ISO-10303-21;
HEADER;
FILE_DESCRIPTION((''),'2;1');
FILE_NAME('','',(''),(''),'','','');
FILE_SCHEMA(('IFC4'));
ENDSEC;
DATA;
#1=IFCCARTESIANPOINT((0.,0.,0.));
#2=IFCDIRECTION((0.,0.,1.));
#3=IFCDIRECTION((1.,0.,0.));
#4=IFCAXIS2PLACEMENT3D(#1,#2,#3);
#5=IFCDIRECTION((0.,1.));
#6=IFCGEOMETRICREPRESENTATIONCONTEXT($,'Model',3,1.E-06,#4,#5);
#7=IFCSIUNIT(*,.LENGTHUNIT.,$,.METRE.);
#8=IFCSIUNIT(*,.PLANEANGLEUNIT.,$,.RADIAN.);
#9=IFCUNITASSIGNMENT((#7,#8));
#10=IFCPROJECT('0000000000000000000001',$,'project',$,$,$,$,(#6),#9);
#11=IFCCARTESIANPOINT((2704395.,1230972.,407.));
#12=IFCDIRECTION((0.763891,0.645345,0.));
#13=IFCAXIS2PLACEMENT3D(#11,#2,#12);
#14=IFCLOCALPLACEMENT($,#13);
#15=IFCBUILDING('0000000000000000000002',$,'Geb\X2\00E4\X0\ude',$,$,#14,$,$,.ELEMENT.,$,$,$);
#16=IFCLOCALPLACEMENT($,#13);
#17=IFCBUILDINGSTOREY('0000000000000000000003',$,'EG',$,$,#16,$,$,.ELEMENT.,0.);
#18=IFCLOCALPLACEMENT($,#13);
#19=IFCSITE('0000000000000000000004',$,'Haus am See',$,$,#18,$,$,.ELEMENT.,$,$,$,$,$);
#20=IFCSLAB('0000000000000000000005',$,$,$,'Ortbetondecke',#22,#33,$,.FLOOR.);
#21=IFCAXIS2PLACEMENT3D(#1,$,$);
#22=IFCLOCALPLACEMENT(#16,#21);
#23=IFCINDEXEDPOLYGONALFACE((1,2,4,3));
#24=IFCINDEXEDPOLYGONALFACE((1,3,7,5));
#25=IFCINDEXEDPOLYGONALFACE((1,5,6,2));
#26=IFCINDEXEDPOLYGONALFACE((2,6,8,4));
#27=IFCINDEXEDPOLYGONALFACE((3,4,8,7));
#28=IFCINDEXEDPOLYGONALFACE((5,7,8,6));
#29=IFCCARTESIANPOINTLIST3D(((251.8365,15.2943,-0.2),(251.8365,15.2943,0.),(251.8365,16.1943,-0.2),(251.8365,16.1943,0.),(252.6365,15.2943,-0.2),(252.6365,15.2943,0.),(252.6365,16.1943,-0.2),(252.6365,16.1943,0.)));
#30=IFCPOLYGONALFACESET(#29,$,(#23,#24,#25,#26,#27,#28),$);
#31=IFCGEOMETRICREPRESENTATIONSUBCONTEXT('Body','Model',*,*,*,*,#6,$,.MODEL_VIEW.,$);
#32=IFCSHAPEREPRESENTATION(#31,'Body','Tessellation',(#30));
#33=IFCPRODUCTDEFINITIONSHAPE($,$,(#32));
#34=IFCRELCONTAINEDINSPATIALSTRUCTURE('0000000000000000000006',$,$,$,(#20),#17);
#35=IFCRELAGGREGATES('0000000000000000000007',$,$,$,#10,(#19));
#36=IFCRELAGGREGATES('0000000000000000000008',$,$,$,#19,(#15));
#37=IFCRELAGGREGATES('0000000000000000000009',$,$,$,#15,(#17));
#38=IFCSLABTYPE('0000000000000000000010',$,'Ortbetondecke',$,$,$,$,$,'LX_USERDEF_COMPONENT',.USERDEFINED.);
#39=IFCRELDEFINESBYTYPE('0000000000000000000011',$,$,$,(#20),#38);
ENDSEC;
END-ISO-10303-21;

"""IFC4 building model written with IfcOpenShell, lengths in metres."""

from ifc_helpers import new_model, si_unit, direction, frame, origin_with_axes, origin_2d_with_axis, place, context, subcontext, project, spatial, rectangle, extrude, type_object, element, save


model = new_model("IFC4")

# Units and contexts
model_context = context("Model", 3, precision=1e-06, world=origin_with_axes(), true_north=direction((0.0, 1.0)))
body_context = subcontext(model_context, "Body", "Model", "MODEL_VIEW")
ifc_project = project(units=[si_unit("LENGTHUNIT", "METRE"), si_unit("PLANEANGLEUNIT", "RADIAN")], contexts=[model_context])

# Site, building, storey
site_placement = place(None, frame((2704395.0, 1230972.0, 407.0), z_axis=(0.0, 0.0, 1.0), x_axis=(0.763891, 0.645345, 0.0)))
site = spatial("IfcSite", under=ifc_project, at=site_placement, Name="Haus am See", CompositionType="ELEMENT")
building_placement = place(None, frame((2704395.0, 1230972.0, 407.0), z_axis=(0.0, 0.0, 1.0), x_axis=(0.763891, 0.645345, 0.0)))
building = spatial("IfcBuilding", under=site, at=building_placement, Name="Gebäude", CompositionType="ELEMENT")
storey_placement = place(None, frame((2704395.0, 1230972.0, 407.0), z_axis=(0.0, 0.0, 1.0), x_axis=(0.763891, 0.645345, 0.0)))
storey = spatial("IfcBuildingStorey", under=building, at=storey_placement, Name="EG", CompositionType="ELEMENT", Elevation=0.0)

# Slab
slab_type = type_object("IfcSlabType", Name="Ortbetondecke", ElementType="LX_USERDEF_COMPONENT", PredefinedType="USERDEFINED")
slab_placement = place(storey_placement, frame((252.2365, 15.7443, -0.2), z_axis=(0.0, 0.0, -1.0), x_axis=(0.0, 1.0, 0.0)))
element("IfcSlab", 1, at=slab_placement, inside=storey, type_object=slab_type, ObjectType="Ortbetondecke", PredefinedType="FLOOR", context=body_context, shape_type="SweptSolid", body=[
    extrude(rectangle(XDim=0.9, YDim=0.8, at=origin_2d_with_axis()), origin_with_axes(), (0.0, 0.0, -1.0), 0.2),
])

save(model, "model.ifc")
